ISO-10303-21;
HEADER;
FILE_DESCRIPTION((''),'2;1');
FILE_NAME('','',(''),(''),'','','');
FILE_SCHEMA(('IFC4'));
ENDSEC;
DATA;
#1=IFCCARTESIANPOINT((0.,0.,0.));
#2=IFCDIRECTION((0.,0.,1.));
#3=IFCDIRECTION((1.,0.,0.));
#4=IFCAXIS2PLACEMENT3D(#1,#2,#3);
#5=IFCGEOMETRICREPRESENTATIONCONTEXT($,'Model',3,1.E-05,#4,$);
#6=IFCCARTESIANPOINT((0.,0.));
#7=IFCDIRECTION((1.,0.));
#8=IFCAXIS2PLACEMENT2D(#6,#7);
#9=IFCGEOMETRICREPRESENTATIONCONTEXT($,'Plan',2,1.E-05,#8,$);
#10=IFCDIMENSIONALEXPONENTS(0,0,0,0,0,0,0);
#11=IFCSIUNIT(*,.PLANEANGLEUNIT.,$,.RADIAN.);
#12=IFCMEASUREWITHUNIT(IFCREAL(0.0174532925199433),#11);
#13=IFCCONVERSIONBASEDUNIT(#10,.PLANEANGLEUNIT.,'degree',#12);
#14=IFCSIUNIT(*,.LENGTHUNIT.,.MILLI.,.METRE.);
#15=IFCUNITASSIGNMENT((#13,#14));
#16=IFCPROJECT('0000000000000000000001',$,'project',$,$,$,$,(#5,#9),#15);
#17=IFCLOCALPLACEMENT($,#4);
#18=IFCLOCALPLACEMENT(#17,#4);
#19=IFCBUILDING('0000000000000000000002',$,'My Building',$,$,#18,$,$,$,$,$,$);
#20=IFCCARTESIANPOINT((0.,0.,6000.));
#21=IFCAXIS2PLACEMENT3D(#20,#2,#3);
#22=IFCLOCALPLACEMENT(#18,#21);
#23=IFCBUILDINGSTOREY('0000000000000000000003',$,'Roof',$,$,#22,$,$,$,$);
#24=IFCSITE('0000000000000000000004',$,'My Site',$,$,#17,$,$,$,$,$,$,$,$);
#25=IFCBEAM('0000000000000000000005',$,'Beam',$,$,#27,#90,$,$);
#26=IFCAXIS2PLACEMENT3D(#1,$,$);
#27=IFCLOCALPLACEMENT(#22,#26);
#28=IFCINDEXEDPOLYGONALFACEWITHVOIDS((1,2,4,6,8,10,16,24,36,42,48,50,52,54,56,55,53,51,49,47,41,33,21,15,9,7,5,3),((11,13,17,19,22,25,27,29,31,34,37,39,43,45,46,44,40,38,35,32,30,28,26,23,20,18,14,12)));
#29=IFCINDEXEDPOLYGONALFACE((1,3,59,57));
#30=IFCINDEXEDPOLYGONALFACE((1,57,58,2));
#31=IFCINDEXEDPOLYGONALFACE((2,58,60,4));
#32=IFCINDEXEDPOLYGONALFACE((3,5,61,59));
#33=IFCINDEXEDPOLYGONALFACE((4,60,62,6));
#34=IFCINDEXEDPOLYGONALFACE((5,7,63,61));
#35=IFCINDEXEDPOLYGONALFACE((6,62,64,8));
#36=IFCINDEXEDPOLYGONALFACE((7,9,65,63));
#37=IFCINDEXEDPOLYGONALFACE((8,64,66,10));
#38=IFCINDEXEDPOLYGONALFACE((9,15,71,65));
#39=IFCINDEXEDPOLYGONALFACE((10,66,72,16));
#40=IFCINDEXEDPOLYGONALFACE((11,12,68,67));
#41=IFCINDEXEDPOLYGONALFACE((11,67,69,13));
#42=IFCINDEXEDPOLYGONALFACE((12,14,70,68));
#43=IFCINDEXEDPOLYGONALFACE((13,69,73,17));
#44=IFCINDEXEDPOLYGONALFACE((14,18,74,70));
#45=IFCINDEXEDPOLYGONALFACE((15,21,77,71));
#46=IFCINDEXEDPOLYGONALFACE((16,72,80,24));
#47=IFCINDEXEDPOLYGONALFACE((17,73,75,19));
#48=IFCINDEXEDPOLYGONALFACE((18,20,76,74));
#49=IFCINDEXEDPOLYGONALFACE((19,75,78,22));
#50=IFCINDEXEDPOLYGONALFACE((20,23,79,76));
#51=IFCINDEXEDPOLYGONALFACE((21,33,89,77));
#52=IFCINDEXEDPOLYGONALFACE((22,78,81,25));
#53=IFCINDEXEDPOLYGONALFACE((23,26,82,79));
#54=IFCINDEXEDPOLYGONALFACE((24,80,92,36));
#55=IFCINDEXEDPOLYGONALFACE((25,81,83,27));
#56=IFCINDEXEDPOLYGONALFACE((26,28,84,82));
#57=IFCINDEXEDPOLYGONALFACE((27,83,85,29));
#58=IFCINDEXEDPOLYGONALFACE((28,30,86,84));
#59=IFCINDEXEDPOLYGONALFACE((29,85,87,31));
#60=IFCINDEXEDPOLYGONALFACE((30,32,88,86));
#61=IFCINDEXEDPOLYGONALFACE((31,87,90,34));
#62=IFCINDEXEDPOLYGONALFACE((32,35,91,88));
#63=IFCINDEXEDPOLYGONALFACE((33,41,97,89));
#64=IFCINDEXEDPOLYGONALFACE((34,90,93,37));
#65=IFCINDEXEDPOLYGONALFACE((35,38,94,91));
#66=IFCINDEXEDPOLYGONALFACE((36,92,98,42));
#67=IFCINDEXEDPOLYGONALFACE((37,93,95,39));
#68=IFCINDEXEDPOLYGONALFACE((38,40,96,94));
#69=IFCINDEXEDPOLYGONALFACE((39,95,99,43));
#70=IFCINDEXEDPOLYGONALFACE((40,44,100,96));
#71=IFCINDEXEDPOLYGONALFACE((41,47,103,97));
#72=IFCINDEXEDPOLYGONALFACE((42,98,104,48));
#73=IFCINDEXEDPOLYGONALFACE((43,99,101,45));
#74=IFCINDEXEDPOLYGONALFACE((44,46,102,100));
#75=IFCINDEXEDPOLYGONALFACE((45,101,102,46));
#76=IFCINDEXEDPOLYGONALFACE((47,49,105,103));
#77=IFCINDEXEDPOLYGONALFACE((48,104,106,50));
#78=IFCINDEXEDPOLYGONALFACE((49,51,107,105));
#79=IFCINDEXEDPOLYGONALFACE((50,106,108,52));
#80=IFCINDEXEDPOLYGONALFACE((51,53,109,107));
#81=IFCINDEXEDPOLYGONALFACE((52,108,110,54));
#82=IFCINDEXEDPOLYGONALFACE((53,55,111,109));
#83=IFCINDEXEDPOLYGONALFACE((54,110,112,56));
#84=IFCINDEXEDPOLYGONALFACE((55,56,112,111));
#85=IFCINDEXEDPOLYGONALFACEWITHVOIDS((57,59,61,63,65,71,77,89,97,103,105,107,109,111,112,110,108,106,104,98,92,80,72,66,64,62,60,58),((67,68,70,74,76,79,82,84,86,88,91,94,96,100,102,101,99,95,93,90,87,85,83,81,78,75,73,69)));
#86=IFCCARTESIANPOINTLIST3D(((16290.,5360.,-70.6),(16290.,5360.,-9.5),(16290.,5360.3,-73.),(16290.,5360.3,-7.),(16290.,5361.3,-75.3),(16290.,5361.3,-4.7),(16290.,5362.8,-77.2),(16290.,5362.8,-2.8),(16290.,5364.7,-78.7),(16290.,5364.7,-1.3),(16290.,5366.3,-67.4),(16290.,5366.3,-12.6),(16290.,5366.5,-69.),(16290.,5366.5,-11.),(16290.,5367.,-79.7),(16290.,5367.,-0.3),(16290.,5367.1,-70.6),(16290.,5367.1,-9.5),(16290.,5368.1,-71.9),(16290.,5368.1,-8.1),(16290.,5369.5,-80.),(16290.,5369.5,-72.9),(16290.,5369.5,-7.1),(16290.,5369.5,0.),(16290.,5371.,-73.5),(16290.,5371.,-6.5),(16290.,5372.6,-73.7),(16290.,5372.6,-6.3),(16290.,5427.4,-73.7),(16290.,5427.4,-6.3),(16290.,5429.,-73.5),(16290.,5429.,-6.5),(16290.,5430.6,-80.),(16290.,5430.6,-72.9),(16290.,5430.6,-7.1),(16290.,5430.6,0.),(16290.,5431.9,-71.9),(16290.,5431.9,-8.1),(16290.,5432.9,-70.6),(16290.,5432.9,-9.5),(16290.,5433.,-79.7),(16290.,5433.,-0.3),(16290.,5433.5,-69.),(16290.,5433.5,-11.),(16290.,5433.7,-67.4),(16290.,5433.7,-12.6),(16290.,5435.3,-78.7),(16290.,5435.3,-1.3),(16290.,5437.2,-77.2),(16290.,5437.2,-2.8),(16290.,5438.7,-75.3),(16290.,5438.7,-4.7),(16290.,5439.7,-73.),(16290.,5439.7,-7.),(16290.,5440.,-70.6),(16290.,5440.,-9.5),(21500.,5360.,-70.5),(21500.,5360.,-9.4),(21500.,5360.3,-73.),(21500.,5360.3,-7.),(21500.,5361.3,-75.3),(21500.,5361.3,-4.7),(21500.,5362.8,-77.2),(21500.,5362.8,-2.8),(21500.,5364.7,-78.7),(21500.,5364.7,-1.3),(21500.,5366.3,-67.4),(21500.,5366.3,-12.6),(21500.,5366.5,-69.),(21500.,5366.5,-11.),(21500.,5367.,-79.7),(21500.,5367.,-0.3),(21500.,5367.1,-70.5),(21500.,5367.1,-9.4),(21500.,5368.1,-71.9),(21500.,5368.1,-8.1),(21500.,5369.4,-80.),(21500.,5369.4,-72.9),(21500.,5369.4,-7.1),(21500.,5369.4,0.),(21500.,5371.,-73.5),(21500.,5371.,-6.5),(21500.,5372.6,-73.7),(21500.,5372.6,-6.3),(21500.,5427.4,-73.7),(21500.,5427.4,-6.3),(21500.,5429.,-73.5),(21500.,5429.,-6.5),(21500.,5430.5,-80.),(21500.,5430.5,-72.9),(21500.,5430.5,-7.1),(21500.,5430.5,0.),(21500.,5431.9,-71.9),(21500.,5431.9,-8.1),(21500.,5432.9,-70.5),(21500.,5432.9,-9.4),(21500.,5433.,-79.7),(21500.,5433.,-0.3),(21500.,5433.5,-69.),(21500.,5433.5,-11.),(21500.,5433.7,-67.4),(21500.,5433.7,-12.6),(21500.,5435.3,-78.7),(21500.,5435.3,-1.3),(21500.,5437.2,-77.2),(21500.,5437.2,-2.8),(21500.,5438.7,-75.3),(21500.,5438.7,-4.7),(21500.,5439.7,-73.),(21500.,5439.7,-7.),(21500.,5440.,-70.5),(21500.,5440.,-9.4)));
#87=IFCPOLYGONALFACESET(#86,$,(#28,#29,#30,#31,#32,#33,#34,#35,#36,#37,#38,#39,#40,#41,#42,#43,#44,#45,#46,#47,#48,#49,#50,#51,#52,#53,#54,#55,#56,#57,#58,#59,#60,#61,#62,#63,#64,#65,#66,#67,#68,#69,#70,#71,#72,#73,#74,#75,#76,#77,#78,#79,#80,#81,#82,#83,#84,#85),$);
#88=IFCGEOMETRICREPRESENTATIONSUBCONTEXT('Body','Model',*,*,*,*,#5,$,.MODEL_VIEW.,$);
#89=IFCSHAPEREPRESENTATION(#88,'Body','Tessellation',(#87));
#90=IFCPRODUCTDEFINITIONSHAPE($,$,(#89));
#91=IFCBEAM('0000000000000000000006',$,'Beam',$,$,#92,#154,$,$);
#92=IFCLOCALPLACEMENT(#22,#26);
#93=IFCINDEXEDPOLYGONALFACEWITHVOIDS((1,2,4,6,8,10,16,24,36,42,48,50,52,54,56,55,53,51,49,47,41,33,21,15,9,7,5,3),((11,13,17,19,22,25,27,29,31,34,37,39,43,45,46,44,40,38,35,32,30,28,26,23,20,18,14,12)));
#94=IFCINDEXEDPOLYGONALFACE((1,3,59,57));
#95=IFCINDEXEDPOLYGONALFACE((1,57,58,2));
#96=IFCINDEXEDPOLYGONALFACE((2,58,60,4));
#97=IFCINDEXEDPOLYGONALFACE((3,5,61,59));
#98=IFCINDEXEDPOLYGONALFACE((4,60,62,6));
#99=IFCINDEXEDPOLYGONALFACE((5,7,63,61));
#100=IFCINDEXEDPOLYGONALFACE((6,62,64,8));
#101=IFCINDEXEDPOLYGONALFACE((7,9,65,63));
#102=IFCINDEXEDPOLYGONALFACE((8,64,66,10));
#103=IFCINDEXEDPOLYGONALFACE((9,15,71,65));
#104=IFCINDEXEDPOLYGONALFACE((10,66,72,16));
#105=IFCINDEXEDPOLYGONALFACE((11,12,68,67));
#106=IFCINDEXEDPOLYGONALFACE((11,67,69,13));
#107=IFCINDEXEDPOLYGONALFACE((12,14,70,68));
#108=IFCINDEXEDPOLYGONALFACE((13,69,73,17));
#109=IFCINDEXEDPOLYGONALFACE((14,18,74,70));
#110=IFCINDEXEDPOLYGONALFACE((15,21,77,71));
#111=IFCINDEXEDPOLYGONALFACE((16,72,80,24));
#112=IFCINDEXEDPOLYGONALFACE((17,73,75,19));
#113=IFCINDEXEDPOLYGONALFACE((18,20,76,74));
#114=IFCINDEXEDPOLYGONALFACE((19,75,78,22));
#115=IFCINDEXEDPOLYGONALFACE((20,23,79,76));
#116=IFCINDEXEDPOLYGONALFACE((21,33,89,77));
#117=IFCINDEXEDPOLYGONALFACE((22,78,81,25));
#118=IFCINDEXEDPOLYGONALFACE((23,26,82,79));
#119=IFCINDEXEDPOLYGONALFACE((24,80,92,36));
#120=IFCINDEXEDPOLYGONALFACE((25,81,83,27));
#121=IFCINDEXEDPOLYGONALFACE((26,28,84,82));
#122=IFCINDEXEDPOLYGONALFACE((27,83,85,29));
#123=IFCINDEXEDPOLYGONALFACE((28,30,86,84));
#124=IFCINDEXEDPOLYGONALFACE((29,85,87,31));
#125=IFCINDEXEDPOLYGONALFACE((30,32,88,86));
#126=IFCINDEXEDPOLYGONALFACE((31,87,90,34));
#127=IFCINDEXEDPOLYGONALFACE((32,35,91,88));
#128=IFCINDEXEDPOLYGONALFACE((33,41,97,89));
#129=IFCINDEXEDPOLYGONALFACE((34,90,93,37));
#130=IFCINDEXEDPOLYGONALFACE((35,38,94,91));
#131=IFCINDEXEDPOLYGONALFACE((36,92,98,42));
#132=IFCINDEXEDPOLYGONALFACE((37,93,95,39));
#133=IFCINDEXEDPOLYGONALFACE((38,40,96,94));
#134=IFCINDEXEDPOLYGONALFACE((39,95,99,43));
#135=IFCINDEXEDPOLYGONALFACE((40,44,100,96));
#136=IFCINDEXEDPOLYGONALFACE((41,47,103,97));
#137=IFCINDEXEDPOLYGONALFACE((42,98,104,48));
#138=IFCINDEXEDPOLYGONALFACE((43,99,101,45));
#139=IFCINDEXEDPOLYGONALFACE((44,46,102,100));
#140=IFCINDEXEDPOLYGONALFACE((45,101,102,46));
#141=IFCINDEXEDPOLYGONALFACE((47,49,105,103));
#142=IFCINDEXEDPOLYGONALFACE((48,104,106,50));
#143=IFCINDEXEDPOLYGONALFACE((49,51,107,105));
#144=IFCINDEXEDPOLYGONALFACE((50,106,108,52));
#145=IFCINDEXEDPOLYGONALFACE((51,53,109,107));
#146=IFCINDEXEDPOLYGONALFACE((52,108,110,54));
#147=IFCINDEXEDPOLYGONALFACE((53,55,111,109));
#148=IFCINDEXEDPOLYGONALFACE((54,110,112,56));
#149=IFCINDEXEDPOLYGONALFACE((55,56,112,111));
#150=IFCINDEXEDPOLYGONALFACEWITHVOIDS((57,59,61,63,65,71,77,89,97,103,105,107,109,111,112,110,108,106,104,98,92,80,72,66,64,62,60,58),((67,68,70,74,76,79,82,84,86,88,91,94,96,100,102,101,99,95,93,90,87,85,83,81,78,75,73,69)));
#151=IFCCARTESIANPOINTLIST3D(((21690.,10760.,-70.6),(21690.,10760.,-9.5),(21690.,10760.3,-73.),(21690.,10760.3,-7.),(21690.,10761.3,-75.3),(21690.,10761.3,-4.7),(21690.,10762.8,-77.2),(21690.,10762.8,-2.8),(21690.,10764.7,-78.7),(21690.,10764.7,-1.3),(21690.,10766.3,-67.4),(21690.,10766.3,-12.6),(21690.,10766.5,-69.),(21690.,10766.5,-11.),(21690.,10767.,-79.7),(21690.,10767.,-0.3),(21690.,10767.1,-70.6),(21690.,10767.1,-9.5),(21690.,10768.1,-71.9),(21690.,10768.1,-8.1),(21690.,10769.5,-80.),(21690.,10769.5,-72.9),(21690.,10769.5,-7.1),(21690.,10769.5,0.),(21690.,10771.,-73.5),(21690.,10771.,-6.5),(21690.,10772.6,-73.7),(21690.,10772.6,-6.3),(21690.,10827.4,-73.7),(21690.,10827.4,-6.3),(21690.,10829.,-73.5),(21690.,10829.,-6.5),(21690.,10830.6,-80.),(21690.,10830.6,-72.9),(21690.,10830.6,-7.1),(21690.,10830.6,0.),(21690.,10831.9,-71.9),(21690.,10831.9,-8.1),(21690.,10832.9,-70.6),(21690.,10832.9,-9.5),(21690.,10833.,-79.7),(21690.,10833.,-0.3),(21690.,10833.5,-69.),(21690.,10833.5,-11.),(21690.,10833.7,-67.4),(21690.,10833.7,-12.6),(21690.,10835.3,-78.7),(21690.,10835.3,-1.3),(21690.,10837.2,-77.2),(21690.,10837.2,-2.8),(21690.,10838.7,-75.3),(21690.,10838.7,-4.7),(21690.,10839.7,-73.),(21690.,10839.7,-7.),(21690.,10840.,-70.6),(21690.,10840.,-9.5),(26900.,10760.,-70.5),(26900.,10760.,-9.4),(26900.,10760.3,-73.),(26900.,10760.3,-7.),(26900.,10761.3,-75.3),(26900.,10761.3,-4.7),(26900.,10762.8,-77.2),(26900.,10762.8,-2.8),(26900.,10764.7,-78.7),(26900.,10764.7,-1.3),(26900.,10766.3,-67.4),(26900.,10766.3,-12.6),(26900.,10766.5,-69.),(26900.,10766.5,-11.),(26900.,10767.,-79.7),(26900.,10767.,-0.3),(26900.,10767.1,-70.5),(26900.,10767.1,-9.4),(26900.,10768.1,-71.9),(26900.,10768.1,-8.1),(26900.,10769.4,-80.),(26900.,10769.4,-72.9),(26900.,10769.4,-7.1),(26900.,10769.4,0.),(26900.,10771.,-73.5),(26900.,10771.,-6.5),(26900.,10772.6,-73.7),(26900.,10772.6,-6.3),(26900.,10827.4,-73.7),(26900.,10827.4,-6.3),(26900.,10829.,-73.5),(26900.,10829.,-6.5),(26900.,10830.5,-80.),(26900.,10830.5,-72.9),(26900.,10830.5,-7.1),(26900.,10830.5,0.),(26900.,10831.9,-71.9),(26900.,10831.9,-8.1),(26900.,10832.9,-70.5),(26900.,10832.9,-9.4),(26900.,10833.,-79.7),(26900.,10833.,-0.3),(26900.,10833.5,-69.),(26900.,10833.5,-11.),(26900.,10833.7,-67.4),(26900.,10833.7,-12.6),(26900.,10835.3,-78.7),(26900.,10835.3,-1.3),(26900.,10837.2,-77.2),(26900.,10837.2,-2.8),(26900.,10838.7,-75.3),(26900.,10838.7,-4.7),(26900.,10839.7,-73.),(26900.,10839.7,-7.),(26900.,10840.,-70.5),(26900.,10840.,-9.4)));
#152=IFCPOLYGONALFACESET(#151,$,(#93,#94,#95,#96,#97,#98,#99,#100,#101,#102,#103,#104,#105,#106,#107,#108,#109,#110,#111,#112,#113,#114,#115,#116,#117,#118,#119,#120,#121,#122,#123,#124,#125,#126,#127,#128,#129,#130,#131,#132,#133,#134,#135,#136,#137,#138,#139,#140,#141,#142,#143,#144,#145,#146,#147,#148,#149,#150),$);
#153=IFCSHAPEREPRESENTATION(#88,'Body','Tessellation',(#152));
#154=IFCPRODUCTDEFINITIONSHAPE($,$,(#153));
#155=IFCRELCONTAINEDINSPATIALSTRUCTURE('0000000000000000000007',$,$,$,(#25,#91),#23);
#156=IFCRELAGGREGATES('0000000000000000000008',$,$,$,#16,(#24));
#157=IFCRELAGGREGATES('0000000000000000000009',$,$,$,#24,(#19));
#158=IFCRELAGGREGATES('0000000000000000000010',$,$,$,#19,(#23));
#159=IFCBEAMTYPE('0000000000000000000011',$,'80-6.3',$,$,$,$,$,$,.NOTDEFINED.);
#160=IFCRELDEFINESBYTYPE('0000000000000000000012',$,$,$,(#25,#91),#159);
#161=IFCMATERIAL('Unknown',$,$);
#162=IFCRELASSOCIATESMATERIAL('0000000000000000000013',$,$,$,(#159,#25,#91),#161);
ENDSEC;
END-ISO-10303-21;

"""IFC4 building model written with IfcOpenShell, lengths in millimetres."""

from ifc_helpers import new_model, entity, si_unit, converted_unit, frame, origin_with_axes, origin_2d_with_axis, place, context, subcontext, project, spatial, hollow_rectangle, extrude, material, material_profile, profile_set, profile_usage, type_object, element, save


model = new_model("IFC4")

# Units and contexts
model_context = context("Model", 3, precision=1e-05, world=origin_with_axes())
plan_context = context("Plan", 2, precision=1e-05, world=origin_2d_with_axis())
body_context = subcontext(model_context, "Body", "Model", "MODEL_VIEW")
ifc_project = project(units=[converted_unit("PLANEANGLEUNIT", "degree", entity("IfcReal", 0.0174532925199433), si_unit("PLANEANGLEUNIT", "RADIAN"), dimensions=[0, 0, 0, 0, 0, 0, 0]), si_unit("LENGTHUNIT", "METRE", prefix="MILLI")], contexts=[model_context, plan_context])

# Site, building, storey
site_placement = place(None, origin_with_axes())
site = spatial("IfcSite", under=ifc_project, at=site_placement, Name="My Site")
building_placement = place(site_placement, origin_with_axes())
building = spatial("IfcBuilding", under=site, at=building_placement, Name="My Building")
storey_placement = place(building_placement, frame((0.0, 0.0, 6000.0), z_axis=(0.0, 0.0, 1.0), x_axis=(1.0, 0.0, 0.0)))
storey = spatial("IfcBuildingStorey", under=building, at=storey_placement, Name="Roof")

# Beams
ifc_material = material(Name="Unknown")
ifc_material_profile_1 = material_profile(ifc_material, hollow_rectangle(XDim=80.0, YDim=80.0, WallThickness=6.3, InnerFilletRadius=6.3, OuterFilletRadius=9.4))
ifc_profile_set_1 = profile_set([ifc_material_profile_1])
ifc_profile_usage_1 = profile_usage(ifc_profile_set_1, cardinal=8)
beam_type_1 = type_object("IfcBeamType", Name="80-6.3", PredefinedType="NOTDEFINED", material=ifc_profile_set_1)
beam_1_placement = place(storey_placement, frame((16290.0, 5400.0, 0.0), z_axis=(1.0, 0.0, 0.0), x_axis=(0.0, 1.0, 0.0)))
element("IfcBeam", 1, at=beam_1_placement, inside=storey, type_object=beam_type_1, material=ifc_profile_usage_1, Name="Beam", context=body_context, shape_type="SweptSolid", body=[
    extrude(hollow_rectangle(XDim=80.0, YDim=80.0, WallThickness=6.3, InnerFilletRadius=6.3, OuterFilletRadius=9.4), frame((0.0, -40.0, 0.0), z_axis=(0.0, 0.0, 1.0), x_axis=(1.0, 0.0, 0.0)), (0.0, 0.0, 1.0), 5210.0),
])
ifc_profile_usage_2 = profile_usage(ifc_profile_set_1, cardinal=8)
beam_2_placement = place(storey_placement, frame((21690.0, 10800.0, 0.0), z_axis=(1.0, 0.0, 0.0), x_axis=(0.0, 1.0, 0.0)))
element("IfcBeam", 2, at=beam_2_placement, inside=storey, type_object=beam_type_1, material=ifc_profile_usage_2, Name="Beam", context=body_context, shape_type="SweptSolid", body=[
    extrude(hollow_rectangle(XDim=80.0, YDim=80.0, WallThickness=6.3, InnerFilletRadius=6.3, OuterFilletRadius=9.4), frame((0.0, -40.0, 0.0), z_axis=(0.0, 0.0, 1.0), x_axis=(1.0, 0.0, 0.0)), (0.0, 0.0, 1.0), 5210.0),
])

save(model, "model.ifc")
